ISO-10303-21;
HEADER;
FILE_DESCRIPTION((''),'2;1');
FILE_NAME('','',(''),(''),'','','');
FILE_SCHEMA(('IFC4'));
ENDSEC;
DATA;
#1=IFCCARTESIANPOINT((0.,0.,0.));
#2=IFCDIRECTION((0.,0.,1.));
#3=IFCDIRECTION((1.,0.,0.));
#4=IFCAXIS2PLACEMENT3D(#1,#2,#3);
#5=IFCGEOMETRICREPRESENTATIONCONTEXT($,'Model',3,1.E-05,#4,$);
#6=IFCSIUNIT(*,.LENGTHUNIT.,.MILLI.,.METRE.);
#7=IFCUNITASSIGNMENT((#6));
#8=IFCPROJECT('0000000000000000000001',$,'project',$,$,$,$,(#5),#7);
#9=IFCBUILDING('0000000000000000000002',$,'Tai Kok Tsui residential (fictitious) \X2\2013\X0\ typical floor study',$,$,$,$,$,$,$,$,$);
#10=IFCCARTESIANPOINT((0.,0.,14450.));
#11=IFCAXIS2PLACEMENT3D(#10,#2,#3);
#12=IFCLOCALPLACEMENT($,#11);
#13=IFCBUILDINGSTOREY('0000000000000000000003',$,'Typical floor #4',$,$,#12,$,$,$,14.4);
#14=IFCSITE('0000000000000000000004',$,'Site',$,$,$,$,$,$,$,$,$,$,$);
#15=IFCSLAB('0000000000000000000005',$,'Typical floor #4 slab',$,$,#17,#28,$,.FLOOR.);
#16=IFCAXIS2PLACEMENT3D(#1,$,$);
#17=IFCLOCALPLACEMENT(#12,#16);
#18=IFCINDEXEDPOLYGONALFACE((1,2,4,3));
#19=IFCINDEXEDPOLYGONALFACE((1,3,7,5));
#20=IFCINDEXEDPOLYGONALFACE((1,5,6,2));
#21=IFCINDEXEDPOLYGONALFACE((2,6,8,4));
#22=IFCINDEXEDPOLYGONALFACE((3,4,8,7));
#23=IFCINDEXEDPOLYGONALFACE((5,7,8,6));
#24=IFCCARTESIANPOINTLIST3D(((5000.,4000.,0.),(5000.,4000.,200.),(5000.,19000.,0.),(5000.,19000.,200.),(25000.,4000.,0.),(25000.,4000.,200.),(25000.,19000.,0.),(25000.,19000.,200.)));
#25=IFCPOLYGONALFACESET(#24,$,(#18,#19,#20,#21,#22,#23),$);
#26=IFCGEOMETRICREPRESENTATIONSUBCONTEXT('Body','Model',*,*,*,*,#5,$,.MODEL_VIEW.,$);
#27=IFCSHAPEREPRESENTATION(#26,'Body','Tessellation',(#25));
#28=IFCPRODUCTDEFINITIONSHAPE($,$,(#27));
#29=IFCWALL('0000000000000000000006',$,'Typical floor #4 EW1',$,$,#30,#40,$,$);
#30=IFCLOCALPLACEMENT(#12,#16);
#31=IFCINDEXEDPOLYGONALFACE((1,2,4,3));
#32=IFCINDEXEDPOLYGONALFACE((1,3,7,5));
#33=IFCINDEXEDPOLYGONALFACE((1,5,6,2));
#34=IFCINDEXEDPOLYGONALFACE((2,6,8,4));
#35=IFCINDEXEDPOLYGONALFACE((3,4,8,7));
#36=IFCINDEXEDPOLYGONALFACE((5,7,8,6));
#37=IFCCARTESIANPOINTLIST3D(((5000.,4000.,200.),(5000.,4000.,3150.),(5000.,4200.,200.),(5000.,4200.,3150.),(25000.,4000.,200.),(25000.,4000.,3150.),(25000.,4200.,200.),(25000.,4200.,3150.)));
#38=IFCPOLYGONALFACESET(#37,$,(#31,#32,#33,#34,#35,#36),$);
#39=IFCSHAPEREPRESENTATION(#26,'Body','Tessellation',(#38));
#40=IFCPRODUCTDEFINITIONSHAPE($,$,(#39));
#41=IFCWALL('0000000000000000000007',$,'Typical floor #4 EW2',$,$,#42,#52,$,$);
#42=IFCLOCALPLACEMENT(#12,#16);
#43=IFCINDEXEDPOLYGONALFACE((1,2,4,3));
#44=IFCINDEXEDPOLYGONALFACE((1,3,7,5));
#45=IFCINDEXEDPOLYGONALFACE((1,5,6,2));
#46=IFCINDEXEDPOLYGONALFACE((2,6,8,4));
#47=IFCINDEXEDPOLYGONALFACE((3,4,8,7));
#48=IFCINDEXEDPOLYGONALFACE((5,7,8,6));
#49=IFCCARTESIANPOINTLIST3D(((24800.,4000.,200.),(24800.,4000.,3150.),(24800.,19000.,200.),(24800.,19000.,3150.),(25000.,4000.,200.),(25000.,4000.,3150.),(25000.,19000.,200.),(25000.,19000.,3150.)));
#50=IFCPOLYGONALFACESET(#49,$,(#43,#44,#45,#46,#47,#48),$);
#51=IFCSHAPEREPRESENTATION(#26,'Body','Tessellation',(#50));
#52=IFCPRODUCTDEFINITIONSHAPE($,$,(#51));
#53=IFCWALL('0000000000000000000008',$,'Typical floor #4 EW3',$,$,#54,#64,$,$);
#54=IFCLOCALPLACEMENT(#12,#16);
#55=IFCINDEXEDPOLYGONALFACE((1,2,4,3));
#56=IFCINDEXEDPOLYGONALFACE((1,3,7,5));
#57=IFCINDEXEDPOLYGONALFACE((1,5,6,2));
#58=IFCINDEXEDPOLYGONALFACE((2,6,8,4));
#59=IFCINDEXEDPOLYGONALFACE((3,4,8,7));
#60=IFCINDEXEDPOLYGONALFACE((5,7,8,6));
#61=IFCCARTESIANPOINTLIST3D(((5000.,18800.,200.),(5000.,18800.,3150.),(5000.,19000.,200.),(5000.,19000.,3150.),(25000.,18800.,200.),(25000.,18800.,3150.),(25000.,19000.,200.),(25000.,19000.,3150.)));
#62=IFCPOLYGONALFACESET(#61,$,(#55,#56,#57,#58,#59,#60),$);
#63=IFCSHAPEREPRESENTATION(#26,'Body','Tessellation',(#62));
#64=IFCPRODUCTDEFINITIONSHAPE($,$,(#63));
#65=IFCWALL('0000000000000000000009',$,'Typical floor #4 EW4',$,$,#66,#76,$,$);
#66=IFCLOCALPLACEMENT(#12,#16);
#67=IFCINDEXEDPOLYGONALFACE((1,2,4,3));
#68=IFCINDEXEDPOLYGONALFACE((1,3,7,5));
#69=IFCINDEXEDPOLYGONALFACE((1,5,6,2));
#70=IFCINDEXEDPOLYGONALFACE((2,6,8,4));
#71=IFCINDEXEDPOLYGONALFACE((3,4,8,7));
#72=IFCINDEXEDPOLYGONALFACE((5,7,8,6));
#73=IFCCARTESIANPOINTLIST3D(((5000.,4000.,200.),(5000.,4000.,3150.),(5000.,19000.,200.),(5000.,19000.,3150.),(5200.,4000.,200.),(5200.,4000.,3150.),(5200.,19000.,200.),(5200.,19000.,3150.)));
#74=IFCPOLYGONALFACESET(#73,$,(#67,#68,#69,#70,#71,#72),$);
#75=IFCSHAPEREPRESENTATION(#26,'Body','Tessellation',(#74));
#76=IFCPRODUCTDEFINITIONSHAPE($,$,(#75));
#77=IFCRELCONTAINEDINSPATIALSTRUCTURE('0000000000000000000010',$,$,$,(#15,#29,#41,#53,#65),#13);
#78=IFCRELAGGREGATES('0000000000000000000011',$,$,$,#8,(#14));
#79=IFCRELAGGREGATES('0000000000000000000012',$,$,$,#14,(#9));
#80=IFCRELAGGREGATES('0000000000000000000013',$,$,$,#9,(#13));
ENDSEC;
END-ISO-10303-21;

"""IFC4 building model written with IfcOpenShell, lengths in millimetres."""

from ifc_helpers import new_model, si_unit, frame, origin_with_axes, place, context, subcontext, project, spatial, indexed_curve, outline, extrude, element, save


model = new_model("IFC4")

# Units and contexts
model_context = context("Model", 3, precision=1e-05, world=origin_with_axes())
body_context = subcontext(model_context, "Body", "Model", "MODEL_VIEW")
ifc_project = project(units=[si_unit("LENGTHUNIT", "METRE", prefix="MILLI")], contexts=[model_context])

# Site, building, storey
site = spatial("IfcSite", under=ifc_project, Name="Site")
building = spatial("IfcBuilding", under=site, Name="Tai Kok Tsui residential (fictitious) – typical floor study")
storey_placement = place(None, frame((0.0, 0.0, 14450.0), z_axis=(0.0, 0.0, 1.0), x_axis=(1.0, 0.0, 0.0)))
storey = spatial("IfcBuildingStorey", under=building, at=storey_placement, Name="Typical floor #4", Elevation=14.4)

# Slab
slab_placement = place(storey_placement, origin_with_axes())
element("IfcSlab", 1, at=slab_placement, inside=storey, Name="Typical floor #4 slab", PredefinedType="FLOOR", context=body_context, shape_type="SweptSolid", body=[
    extrude(outline(indexed_curve([(5000.0, 4000.0), (25000.0, 4000.0), (25000.0, 19000.0), (5000.0, 19000.0)])), None, (0.0, 0.0, 1.0), 200.0),
])

# Walls
wall_1_placement = place(storey_placement, frame((5000.0, 4000.0, 200.0), z_axis=(0.0, 0.0, 1.0), x_axis=(1.0, 0.0, 0.0)))
element("IfcWall", 2, at=wall_1_placement, inside=storey, Name="Typical floor #4 EW1", context=body_context, shape_type="SweptSolid", body=[
    extrude(outline(indexed_curve([(0.0, 0.0), (0.0, 200.0), (20000.0, 200.0), (20000.0, 0.0), (0.0, 0.0)], self_intersect=False)), origin_with_axes(), (0.0, 0.0, 1.0), 2950.0),
])
wall_2_placement = place(storey_placement, frame((25000.0, 4000.0, 200.0), z_axis=(0.0, 0.0, 1.0), x_axis=(0.0, 1.0, 0.0)))
element("IfcWall", 3, at=wall_2_placement, inside=storey, Name="Typical floor #4 EW2", context=body_context, shape_type="SweptSolid", body=[
    extrude(outline(indexed_curve([(0.0, 0.0), (0.0, 200.0), (15000.0, 200.0), (15000.0, 0.0), (0.0, 0.0)], self_intersect=False)), origin_with_axes(), (0.0, 0.0, 1.0), 2950.0),
])
wall_3_placement = place(storey_placement, frame((25000.0, 19000.0, 200.0), z_axis=(0.0, 0.0, 1.0), x_axis=(-1.0, 0.0, 0.0)))
element("IfcWall", 4, at=wall_3_placement, inside=storey, Name="Typical floor #4 EW3", context=body_context, shape_type="SweptSolid", body=[
    extrude(outline(indexed_curve([(0.0, 0.0), (0.0, 200.0), (20000.0, 200.0), (20000.0, 0.0), (0.0, 0.0)], self_intersect=False)), origin_with_axes(), (0.0, 0.0, 1.0), 2950.0),
])
wall_4_placement = place(storey_placement, frame((5000.0, 19000.0, 200.0), z_axis=(0.0, 0.0, 1.0), x_axis=(0.0, -1.0, 0.0)))
element("IfcWall", 5, at=wall_4_placement, inside=storey, Name="Typical floor #4 EW4", context=body_context, shape_type="SweptSolid", body=[
    extrude(outline(indexed_curve([(0.0, 0.0), (0.0, 200.0), (15000.0, 200.0), (15000.0, 0.0), (0.0, 0.0)], self_intersect=False)), origin_with_axes(), (0.0, 0.0, 1.0), 2950.0),
])

save(model, "model.ifc")
